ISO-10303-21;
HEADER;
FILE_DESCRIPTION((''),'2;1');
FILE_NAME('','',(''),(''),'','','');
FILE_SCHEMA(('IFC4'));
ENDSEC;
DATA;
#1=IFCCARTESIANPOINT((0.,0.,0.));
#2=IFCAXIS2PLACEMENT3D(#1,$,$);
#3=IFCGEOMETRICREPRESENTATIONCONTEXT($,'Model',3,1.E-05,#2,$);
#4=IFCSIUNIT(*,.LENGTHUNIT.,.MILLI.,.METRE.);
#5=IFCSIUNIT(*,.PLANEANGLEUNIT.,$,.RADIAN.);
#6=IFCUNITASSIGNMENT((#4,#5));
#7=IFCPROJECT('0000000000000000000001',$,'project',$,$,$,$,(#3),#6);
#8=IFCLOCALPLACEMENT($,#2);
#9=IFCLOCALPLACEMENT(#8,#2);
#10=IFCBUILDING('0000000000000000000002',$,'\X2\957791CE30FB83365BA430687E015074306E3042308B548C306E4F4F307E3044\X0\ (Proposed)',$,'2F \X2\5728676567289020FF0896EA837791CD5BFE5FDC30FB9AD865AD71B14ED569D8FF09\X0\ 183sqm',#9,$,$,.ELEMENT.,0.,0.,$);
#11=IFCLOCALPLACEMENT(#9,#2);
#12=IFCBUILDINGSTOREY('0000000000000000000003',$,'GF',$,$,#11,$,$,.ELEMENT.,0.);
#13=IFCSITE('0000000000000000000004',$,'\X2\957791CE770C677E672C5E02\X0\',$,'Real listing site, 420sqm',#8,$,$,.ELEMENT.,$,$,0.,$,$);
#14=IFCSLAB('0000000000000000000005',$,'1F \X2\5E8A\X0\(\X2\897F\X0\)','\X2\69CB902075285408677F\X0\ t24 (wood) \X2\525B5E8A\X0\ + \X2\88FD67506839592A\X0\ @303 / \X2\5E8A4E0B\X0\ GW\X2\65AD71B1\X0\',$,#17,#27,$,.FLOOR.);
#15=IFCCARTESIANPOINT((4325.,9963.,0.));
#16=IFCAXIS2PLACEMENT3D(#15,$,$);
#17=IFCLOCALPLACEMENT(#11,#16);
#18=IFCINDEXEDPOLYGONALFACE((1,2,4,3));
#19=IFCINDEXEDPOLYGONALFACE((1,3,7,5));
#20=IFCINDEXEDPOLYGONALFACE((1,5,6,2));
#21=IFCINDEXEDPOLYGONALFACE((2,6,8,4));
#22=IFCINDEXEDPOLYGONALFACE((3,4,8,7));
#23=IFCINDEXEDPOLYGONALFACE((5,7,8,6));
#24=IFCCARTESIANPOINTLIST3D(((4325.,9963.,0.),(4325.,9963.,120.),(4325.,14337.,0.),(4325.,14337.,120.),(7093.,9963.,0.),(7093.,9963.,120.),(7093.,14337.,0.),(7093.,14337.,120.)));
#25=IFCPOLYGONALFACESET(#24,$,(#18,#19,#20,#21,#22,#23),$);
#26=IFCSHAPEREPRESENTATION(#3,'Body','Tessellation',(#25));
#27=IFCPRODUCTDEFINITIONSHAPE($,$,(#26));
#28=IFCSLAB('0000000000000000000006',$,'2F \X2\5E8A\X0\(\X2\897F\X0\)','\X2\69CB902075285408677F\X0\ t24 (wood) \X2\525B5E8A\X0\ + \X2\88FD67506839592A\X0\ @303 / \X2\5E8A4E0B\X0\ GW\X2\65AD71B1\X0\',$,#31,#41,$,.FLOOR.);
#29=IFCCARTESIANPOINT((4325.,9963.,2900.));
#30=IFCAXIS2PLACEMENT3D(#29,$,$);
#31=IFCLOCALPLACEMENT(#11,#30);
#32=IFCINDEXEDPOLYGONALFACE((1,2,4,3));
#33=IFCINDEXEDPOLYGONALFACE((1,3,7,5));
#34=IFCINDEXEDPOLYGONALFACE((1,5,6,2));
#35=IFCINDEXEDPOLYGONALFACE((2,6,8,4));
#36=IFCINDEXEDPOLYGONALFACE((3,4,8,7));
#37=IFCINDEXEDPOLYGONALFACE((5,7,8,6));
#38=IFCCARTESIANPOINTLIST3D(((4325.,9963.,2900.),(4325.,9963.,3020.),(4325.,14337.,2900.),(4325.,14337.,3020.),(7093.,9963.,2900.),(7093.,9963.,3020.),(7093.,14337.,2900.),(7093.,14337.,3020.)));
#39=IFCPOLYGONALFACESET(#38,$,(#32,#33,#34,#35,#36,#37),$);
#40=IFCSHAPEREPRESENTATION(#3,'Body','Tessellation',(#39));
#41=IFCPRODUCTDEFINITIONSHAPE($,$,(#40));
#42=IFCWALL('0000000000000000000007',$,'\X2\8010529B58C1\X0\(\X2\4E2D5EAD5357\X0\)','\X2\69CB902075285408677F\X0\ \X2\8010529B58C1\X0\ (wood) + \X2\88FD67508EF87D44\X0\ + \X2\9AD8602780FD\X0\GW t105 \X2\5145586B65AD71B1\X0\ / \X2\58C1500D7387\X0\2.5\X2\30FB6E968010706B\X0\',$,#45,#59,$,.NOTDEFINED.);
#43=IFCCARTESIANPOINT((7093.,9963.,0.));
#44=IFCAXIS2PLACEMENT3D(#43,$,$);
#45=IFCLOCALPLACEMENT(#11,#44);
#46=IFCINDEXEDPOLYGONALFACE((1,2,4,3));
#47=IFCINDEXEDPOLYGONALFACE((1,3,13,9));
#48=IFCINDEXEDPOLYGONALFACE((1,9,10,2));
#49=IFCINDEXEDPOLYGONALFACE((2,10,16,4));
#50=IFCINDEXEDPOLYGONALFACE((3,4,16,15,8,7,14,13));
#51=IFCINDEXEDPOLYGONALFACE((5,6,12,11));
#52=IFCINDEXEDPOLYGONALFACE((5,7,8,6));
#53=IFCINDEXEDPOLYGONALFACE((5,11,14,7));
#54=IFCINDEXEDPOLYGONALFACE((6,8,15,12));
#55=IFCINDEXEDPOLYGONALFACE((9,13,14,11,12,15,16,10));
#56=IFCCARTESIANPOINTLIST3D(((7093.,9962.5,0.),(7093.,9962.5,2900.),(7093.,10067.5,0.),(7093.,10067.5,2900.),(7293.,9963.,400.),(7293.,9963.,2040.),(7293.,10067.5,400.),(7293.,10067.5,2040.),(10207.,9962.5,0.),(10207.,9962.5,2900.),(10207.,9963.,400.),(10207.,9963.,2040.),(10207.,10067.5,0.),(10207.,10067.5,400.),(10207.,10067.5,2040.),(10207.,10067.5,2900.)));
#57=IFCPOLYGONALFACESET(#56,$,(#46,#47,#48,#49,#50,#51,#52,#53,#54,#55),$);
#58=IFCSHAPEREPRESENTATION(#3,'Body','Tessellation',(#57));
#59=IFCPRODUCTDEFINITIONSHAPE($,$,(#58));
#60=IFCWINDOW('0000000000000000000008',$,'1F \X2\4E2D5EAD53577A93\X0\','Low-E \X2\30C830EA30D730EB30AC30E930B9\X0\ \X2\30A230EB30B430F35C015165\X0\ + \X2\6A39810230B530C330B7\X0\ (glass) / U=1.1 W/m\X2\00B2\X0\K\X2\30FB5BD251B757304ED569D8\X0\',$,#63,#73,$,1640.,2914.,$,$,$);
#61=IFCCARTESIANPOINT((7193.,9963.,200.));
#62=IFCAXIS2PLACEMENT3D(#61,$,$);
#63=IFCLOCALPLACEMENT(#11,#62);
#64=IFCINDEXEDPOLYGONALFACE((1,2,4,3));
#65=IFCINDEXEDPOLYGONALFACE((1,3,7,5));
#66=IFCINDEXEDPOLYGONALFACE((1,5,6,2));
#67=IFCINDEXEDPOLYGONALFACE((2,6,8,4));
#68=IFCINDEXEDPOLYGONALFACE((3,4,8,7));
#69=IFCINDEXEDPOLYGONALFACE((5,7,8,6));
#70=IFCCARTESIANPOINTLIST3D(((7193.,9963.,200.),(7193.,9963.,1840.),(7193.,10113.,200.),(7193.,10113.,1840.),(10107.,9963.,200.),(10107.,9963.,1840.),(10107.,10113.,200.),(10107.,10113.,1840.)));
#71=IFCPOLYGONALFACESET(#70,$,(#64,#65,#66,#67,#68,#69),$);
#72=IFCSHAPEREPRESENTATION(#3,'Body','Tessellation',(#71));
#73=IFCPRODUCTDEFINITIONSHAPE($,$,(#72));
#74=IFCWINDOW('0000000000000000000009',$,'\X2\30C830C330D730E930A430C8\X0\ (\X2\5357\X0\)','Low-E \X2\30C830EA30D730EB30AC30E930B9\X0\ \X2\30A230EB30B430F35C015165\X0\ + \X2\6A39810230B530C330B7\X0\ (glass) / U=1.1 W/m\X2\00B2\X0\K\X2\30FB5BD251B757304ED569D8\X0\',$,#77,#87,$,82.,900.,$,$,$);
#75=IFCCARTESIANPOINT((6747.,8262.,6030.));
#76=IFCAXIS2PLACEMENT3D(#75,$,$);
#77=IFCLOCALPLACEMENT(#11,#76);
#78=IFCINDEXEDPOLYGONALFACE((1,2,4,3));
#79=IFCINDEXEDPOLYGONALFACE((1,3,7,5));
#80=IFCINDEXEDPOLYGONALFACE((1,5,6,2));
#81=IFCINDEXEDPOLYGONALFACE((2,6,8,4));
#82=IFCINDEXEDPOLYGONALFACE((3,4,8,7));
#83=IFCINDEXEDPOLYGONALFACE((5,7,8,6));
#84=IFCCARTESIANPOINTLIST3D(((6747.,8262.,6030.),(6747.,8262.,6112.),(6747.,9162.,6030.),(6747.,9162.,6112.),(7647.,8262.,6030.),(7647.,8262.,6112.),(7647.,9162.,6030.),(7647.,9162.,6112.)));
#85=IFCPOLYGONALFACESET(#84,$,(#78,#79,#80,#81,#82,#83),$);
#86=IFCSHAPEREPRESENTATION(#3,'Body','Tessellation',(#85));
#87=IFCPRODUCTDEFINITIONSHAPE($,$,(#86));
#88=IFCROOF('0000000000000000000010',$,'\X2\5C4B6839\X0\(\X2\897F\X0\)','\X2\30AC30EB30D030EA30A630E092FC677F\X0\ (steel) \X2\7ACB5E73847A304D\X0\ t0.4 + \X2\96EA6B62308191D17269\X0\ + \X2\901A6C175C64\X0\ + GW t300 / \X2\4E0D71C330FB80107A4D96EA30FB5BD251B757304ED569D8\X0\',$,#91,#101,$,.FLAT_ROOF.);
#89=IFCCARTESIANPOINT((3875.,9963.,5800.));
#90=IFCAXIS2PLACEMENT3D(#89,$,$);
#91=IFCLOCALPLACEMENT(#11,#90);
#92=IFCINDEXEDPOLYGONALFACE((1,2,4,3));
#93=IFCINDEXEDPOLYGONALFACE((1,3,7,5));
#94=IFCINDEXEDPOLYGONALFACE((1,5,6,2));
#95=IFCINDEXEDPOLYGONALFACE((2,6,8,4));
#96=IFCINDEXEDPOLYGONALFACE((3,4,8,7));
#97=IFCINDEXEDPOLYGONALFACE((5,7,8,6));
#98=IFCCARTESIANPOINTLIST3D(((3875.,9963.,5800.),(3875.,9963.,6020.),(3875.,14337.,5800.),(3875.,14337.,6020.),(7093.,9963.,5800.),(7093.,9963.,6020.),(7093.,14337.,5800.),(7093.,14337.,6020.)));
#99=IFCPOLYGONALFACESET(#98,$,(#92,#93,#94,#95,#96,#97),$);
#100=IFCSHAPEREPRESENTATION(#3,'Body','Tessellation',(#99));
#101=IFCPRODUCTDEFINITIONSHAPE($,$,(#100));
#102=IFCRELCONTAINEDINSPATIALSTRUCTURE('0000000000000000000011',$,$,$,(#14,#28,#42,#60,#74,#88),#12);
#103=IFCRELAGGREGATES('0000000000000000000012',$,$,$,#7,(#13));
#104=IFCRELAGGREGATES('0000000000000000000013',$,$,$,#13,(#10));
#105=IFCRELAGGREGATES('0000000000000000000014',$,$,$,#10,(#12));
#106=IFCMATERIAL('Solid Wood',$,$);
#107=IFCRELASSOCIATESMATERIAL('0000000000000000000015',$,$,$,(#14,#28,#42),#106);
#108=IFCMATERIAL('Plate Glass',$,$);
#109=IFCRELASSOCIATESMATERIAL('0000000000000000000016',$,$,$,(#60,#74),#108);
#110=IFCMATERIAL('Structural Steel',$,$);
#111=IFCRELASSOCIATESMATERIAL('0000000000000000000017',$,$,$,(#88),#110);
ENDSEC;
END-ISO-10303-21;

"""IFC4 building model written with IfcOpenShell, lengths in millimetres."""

from ifc_helpers import new_model, si_unit, frame, frame_2d, origin, place, context, project, spatial, rectangle, extrude, material, element, fill, save


model = new_model("IFC4")

# Units and contexts
model_context = context("Model", 3, precision=1e-05, world=origin())
ifc_project = project(units=[si_unit("LENGTHUNIT", "METRE", prefix="MILLI"), si_unit("PLANEANGLEUNIT", "RADIAN")], contexts=[model_context])

# Site, building, storey
site_placement = place(None, origin())
site = spatial("IfcSite", under=ifc_project, at=site_placement, Name="長野県松本市", ObjectType="Real listing site, 420sqm", CompositionType="ELEMENT", RefElevation=0.0)
building_placement = place(site_placement, origin())
building = spatial("IfcBuilding", under=site, at=building_placement, Name="長野・茶室と縁側のある和の住まい (Proposed)", ObjectType="2F 在来木造（雪荷重対応・高断熱仕様） 183sqm", CompositionType="ELEMENT", ElevationOfRefHeight=0.0, ElevationOfTerrain=0.0)
storey_placement = place(building_placement, origin())
storey = spatial("IfcBuildingStorey", under=building, at=storey_placement, Name="GF", CompositionType="ELEMENT", Elevation=0.0)

# Shared definitions
ifc_material_1 = material(Name="Solid Wood")

# Slabs
slab_1_placement = place(storey_placement, frame((4325.0, 9963.0, 0.0)))
element("IfcSlab", 1, at=slab_1_placement, inside=storey, material=ifc_material_1, Name="1F 床(西)", Description="構造用合板 t24 (wood) 剛床 + 製材根太 @303 / 床下 GW断熱", PredefinedType="FLOOR", context=model_context, shape_type="SweptSolid", body=[
    extrude(rectangle(XDim=2768.0, YDim=4374.0, at=frame_2d((1384.0, 2187.0))), frame((4325.0, 9963.0, 0.0)), (0.0, 0.0, 1.0), 120.0),
])
slab_2_placement = place(storey_placement, frame((4325.0, 9963.0, 2900.0)))
element("IfcSlab", 2, at=slab_2_placement, inside=storey, material=ifc_material_1, Name="2F 床(西)", Description="構造用合板 t24 (wood) 剛床 + 製材根太 @303 / 床下 GW断熱", PredefinedType="FLOOR", context=model_context, shape_type="SweptSolid", body=[
    extrude(rectangle(XDim=2768.0, YDim=4374.0, at=frame_2d((1384.0, 2187.0))), frame((4325.0, 9963.0, 2900.0)), (0.0, 0.0, 1.0), 120.0),
])

# Wall, opening, window
wall_placement = place(storey_placement, frame((7093.0, 9963.0, 0.0)))
wall = element("IfcWall", 3, at=wall_placement, inside=storey, material=ifc_material_1, Name="耐力壁(中庭南)", Description="構造用合板 耐力壁 (wood) + 製材軸組 + 高性能GW t105 充填断熱 / 壁倍率2.5・準耐火", PredefinedType="NOTDEFINED", context=model_context, shape_type="SweptSolid", body=[
    extrude(rectangle(XDim=3114.0, YDim=105.0, at=frame_2d((1557.0, 52.0))), frame((7093.0, 9963.0, 0.0)), (0.0, 0.0, 1.0), 2900.0),
])
opening_placement = place(storey_placement, frame((7193.0, 9963.0, 200.0)))
opening = element("IfcOpeningElement", 4, at=opening_placement, cuts=wall, PredefinedType="NOTDEFINED", context=model_context, shape_type="SweptSolid", body=[
    extrude(rectangle(XDim=2914.0, YDim=150.0, at=frame_2d((1457.0, 75.0))), frame((7193.0, 9963.0, 200.0)), (0.0, 0.0, 1.0), 1640.0),
])
ifc_material_2 = material(Name="Plate Glass")
window_1_placement = place(storey_placement, frame((7193.0, 9963.0, 200.0)))
window_1 = element("IfcWindow", 5, at=window_1_placement, inside=storey, material=ifc_material_2, Name="1F 中庭南窓", Description="Low-E トリプルガラス アルゴン封入 + 樹脂サッシ (glass) / U=1.1 W/m²K・寒冷地仕様", OverallHeight=1640.0, OverallWidth=2914.0, context=model_context, shape_type="SweptSolid", body=[
    extrude(rectangle(XDim=2914.0, YDim=150.0, at=frame_2d((1457.0, 75.0))), frame((7193.0, 9963.0, 200.0)), (0.0, 0.0, 1.0), 1640.0),
])
fill(opening, window_1)

# Window
window_2_placement = place(storey_placement, frame((6747.0, 8262.0, 6030.0)))
element("IfcWindow", 6, at=window_2_placement, inside=storey, material=ifc_material_2, Name="トップライト (南)", Description="Low-E トリプルガラス アルゴン封入 + 樹脂サッシ (glass) / U=1.1 W/m²K・寒冷地仕様", OverallHeight=82.0, OverallWidth=900.0, context=model_context, shape_type="SweptSolid", body=[
    extrude(rectangle(XDim=900.0, YDim=900.0, at=frame_2d((450.0, 450.0))), frame((6747.0, 8262.0, 6030.0)), (0.0, 0.0, 1.0), 82.0),
])

# Roof
ifc_material_3 = material(Name="Structural Steel")
for number, where, name in (
    (7, (3875.0, 9963.0, 5800.0), "屋根(西)"),
):
    element("IfcRoof", number, at=place(storey_placement, frame(where)), inside=storey, material=ifc_material_3, Name=name, Description="ガルバリウム鋼板 (steel) 立平葺き t0.4 + 雪止め金物 + 通気層 + GW t300 / 不燃・耐積雪・寒冷地仕様", PredefinedType="FLAT_ROOF", context=model_context, shape_type="SweptSolid", body=[
        extrude(rectangle(XDim=3218.0, YDim=4374.0, at=frame_2d((1609.0, 2187.0))), frame((3875.0, 9963.0, 5800.0)), (0.0, 0.0, 1.0), 220.0),
    ])

save(model, "model.ifc")
